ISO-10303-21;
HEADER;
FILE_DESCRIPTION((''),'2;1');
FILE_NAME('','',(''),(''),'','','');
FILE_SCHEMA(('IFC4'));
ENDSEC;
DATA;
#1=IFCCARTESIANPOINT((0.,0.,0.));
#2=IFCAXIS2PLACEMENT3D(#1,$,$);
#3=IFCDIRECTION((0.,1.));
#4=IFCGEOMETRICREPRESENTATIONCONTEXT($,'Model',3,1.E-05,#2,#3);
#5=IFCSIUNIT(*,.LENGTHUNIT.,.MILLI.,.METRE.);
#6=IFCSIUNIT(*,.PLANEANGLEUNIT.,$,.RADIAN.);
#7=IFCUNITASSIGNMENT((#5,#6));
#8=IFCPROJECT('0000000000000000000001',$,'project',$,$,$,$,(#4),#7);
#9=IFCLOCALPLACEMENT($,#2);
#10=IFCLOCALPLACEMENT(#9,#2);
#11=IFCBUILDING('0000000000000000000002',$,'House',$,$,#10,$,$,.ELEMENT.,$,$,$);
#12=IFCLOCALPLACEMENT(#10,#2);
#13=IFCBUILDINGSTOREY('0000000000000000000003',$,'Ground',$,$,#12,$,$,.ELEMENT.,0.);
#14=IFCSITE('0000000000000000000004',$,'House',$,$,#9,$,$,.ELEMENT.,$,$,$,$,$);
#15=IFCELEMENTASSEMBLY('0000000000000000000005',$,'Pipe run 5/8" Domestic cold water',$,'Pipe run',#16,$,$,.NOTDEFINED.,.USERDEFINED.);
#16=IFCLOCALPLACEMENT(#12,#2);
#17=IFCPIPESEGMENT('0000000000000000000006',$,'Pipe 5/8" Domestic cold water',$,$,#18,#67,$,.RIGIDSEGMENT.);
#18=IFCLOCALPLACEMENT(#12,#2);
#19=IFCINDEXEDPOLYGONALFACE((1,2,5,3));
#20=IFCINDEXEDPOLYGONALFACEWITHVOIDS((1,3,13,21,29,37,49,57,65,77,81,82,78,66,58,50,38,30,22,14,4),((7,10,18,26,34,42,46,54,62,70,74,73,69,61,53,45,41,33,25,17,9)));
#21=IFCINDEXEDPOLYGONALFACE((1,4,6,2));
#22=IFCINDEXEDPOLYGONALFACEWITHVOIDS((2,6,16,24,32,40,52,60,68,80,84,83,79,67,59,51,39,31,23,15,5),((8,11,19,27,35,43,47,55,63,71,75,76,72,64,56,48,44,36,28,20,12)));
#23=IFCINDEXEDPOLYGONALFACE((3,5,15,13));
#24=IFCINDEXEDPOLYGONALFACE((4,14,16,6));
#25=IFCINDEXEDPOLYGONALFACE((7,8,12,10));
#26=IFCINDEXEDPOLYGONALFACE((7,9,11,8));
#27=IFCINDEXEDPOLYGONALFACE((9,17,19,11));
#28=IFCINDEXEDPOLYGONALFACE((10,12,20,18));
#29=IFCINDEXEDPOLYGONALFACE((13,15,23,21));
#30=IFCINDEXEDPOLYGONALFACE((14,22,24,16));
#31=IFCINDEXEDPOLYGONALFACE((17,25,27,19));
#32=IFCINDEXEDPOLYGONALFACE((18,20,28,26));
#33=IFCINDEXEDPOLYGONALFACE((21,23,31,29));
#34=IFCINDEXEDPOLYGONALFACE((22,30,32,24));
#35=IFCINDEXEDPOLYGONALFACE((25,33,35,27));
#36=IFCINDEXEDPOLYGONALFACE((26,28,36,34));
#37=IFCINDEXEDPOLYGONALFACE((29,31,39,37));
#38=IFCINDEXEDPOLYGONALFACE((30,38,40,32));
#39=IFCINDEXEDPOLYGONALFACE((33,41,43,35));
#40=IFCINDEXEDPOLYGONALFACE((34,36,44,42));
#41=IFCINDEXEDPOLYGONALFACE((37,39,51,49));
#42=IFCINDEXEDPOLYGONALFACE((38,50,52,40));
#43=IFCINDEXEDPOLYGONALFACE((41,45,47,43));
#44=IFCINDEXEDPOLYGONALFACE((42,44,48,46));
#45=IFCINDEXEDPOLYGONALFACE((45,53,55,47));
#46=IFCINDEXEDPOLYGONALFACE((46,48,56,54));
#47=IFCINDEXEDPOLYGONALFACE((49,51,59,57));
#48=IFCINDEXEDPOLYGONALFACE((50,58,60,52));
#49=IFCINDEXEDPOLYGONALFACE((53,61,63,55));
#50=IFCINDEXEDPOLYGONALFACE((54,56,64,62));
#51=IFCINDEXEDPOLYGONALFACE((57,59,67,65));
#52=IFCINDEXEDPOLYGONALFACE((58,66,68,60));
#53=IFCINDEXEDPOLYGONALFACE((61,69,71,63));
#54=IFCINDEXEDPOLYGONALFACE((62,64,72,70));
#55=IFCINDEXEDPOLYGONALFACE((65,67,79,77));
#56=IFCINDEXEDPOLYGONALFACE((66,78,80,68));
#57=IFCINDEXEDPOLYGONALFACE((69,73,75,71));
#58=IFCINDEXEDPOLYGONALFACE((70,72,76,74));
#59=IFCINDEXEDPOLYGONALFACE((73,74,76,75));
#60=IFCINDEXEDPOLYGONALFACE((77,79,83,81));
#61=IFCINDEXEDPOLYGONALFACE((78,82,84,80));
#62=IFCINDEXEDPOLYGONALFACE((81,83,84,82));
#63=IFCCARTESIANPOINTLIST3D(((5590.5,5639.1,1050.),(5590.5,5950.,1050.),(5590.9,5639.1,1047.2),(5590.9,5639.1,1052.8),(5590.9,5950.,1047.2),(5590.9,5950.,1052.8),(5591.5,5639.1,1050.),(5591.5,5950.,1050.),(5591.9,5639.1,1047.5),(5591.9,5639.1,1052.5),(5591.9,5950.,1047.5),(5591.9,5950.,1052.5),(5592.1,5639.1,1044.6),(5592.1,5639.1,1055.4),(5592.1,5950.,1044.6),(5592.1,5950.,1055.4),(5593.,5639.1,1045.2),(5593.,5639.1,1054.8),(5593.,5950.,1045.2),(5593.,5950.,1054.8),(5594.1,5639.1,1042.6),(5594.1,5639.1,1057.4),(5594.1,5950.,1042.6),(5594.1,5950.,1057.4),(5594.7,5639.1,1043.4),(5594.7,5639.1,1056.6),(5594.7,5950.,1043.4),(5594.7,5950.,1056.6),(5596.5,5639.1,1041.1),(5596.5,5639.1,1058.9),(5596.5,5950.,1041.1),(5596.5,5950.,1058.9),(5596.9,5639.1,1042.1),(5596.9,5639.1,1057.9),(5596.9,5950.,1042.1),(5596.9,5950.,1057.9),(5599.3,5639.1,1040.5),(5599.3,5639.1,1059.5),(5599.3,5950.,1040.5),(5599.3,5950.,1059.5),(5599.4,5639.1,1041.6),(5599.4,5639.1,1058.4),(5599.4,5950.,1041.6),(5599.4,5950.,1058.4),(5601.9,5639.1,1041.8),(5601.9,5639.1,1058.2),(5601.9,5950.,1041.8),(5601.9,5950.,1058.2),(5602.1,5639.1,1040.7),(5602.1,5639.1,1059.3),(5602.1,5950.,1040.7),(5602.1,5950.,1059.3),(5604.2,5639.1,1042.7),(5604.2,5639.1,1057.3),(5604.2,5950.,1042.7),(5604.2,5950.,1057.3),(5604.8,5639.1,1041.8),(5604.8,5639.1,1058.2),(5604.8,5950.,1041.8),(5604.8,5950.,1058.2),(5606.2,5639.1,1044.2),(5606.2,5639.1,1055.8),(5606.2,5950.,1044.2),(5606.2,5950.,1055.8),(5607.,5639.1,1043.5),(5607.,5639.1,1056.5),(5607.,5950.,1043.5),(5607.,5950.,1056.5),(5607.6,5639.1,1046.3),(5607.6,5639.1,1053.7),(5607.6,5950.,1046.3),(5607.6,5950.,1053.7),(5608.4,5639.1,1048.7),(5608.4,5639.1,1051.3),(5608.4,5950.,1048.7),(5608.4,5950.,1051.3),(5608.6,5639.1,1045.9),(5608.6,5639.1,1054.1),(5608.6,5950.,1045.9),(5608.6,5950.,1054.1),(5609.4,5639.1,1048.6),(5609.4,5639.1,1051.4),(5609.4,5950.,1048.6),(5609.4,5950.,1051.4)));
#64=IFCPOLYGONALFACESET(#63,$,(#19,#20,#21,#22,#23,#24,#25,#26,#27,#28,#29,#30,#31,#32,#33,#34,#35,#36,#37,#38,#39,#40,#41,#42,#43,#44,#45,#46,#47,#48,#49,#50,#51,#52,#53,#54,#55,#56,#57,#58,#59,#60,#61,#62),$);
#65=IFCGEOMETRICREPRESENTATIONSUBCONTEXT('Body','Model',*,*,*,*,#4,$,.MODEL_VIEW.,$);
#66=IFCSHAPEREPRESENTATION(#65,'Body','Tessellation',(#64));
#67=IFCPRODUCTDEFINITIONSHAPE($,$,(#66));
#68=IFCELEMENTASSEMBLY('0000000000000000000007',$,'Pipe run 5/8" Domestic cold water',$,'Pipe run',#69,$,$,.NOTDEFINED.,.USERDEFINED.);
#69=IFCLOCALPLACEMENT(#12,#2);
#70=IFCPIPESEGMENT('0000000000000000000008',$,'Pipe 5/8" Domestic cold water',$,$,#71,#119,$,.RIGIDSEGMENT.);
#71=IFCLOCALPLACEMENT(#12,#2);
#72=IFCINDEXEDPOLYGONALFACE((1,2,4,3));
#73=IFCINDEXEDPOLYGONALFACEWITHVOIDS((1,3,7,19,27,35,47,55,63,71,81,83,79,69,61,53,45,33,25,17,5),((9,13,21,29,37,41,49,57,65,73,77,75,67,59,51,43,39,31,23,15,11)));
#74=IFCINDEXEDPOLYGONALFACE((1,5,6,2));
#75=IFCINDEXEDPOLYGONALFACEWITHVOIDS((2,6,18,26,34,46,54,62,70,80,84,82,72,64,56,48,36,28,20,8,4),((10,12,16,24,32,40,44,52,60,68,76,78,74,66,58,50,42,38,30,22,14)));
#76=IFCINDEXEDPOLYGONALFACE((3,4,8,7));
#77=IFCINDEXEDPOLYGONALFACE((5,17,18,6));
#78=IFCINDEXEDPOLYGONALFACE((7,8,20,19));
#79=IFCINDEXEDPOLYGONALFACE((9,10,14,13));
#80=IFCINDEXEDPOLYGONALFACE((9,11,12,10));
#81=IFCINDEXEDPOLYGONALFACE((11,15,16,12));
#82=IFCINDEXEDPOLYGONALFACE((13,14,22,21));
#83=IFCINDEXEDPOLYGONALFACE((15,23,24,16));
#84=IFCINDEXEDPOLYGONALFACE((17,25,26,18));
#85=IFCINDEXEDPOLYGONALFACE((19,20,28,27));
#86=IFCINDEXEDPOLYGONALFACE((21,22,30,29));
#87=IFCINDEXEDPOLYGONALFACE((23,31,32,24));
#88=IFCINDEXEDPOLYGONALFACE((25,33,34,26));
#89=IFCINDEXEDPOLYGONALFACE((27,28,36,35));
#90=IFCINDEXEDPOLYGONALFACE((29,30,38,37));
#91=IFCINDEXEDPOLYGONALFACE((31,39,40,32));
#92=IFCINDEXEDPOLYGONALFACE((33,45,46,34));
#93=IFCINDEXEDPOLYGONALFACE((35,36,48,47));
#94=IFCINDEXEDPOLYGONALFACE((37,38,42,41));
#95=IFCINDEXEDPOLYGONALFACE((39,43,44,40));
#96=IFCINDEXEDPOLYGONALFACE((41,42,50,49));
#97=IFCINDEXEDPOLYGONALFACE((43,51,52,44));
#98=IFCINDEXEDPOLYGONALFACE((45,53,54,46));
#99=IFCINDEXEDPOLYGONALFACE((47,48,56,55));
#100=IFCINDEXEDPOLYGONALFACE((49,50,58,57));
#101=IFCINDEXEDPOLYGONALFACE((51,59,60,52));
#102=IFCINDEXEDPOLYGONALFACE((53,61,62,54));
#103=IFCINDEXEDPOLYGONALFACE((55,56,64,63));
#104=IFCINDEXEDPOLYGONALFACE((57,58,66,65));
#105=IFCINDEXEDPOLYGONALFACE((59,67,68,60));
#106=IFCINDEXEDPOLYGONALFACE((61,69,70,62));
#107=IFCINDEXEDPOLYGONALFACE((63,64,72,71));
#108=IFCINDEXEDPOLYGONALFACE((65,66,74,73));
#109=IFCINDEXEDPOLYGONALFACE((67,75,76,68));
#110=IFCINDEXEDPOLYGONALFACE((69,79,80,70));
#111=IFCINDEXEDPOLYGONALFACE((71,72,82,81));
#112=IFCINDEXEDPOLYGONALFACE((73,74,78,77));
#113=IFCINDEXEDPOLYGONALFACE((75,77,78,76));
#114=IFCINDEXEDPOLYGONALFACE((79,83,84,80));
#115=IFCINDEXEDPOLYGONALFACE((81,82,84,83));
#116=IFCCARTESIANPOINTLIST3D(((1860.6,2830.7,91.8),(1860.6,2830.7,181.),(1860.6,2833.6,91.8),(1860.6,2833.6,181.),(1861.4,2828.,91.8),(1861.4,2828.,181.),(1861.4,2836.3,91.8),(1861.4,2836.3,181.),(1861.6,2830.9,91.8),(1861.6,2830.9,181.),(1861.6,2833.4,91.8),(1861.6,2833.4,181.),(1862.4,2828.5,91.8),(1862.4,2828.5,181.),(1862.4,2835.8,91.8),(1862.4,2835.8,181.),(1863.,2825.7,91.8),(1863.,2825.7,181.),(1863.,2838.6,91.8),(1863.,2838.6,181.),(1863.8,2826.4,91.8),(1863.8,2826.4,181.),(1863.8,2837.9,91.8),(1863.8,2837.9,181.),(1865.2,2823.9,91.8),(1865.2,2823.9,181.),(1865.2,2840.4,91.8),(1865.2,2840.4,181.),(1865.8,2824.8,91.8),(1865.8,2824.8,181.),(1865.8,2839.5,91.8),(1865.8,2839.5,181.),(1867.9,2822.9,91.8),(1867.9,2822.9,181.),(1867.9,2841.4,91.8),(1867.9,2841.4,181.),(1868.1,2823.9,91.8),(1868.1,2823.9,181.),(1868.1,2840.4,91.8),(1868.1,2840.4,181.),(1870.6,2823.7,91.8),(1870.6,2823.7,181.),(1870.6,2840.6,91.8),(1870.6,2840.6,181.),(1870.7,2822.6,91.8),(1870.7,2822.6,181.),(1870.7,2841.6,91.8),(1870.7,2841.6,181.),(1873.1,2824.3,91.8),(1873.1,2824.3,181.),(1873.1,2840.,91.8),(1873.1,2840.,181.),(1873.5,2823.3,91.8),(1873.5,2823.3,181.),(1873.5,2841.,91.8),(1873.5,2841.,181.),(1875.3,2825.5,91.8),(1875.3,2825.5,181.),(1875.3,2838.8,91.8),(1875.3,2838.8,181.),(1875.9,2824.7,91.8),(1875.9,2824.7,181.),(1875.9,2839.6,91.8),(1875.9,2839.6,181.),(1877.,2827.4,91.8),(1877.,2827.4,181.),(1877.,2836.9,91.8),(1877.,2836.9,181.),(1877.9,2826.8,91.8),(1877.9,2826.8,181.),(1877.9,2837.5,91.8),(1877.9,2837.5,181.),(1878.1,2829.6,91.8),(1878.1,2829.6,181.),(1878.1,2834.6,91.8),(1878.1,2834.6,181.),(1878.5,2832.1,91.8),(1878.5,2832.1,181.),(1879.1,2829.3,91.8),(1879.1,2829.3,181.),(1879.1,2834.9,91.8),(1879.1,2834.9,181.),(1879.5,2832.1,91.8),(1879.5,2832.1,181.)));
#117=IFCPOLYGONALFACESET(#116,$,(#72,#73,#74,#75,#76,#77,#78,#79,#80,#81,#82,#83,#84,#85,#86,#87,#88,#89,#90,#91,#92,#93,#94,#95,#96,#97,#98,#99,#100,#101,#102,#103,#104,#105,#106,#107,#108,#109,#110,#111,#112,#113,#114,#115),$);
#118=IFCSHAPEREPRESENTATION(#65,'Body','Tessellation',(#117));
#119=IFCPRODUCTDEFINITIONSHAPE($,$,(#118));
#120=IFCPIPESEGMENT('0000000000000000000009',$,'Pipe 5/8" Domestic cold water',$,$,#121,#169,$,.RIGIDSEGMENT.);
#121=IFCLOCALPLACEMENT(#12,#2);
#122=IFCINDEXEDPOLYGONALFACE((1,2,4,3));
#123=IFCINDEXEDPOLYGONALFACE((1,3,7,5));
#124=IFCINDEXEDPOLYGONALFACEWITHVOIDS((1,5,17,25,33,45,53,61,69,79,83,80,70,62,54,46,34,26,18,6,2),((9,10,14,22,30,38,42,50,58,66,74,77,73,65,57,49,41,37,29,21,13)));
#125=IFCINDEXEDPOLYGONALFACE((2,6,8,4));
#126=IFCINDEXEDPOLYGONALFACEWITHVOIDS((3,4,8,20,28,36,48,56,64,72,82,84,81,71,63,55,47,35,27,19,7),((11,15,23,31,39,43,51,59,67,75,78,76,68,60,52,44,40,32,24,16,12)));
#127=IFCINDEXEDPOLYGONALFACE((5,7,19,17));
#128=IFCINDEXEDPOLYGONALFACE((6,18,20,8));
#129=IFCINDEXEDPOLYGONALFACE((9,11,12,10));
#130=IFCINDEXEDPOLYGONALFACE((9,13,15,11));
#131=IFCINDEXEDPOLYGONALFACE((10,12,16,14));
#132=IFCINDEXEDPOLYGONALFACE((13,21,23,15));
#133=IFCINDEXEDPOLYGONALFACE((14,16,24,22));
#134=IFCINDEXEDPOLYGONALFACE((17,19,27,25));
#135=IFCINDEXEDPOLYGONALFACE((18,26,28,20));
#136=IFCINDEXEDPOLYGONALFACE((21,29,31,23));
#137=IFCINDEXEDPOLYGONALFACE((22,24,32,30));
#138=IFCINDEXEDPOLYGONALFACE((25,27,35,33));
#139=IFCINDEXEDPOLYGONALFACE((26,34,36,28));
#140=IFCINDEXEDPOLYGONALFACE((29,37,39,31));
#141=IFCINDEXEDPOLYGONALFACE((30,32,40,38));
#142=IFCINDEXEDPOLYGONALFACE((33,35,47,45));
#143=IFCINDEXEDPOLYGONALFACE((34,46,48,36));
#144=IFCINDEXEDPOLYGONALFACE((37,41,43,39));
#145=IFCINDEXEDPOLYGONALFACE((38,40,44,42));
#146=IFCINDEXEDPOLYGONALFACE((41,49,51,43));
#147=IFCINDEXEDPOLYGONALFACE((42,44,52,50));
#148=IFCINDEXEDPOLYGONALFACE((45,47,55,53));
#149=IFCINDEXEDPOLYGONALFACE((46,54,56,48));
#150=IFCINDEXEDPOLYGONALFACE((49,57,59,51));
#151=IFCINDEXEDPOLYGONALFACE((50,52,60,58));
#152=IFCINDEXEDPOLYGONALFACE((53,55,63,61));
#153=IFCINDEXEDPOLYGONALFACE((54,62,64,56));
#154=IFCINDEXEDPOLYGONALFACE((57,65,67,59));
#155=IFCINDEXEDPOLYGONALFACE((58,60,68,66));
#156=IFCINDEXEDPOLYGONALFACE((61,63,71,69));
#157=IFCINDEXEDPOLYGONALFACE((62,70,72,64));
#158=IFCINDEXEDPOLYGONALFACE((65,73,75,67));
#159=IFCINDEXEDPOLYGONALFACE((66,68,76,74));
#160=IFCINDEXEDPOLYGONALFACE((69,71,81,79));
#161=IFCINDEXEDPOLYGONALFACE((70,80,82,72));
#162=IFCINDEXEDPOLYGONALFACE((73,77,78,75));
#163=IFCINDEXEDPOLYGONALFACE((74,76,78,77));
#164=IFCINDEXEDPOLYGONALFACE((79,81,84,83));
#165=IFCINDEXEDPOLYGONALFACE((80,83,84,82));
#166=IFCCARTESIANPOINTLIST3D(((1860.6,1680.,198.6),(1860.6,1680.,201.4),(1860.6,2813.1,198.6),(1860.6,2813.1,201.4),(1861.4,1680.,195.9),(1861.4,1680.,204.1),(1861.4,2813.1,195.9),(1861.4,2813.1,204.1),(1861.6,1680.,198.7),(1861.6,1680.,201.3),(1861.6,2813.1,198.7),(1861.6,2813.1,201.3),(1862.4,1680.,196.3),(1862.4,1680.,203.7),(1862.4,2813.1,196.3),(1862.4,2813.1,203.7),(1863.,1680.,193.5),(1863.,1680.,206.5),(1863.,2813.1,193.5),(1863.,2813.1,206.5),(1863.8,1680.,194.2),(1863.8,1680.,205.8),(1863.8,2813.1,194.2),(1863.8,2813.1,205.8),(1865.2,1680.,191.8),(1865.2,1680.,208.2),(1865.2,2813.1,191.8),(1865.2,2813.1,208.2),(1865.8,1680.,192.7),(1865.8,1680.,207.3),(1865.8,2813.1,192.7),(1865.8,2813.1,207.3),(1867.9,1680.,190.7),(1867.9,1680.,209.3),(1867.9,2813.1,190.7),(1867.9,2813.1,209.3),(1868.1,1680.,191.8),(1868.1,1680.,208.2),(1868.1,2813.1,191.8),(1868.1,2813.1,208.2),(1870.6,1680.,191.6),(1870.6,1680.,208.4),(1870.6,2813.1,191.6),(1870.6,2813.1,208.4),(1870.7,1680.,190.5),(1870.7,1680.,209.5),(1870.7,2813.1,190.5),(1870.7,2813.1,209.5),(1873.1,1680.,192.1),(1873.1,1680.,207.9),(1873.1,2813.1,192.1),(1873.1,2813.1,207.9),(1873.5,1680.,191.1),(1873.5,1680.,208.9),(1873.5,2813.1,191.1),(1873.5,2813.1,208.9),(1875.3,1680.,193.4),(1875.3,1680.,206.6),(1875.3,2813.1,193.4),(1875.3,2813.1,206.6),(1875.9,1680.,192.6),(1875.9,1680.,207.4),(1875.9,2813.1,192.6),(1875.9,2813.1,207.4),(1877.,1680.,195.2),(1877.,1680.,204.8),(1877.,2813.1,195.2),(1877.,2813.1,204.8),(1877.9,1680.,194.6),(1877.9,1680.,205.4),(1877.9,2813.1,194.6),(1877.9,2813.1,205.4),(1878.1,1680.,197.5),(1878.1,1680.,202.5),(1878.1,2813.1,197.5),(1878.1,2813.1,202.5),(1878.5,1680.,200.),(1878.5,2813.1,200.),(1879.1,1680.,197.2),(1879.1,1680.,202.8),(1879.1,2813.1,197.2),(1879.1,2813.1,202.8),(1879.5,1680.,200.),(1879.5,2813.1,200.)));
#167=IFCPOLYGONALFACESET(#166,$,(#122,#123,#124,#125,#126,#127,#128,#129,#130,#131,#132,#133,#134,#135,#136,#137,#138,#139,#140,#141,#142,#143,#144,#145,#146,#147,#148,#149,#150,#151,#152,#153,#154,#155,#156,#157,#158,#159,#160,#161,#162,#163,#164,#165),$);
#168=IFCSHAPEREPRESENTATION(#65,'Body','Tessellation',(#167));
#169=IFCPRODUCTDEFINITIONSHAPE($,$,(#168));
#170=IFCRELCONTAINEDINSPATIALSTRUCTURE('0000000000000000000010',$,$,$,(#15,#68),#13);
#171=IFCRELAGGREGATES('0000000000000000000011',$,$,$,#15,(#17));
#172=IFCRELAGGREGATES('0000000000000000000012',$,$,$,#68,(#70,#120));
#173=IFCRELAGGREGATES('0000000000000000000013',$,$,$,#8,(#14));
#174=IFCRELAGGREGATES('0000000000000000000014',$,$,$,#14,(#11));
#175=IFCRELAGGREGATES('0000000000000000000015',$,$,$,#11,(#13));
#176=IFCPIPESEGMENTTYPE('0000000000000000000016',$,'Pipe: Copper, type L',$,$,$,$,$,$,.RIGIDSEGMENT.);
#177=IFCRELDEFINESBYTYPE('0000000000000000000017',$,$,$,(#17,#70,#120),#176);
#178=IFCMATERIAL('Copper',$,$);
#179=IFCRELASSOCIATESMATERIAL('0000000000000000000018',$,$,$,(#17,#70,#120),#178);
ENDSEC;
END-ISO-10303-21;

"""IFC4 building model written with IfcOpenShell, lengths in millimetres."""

from ifc_helpers import new_model, si_unit, direction, frame, origin, origin_with_axes, origin_2d, place, context, subcontext, project, spatial, hollow_circle, extrude, material, type_object, element, aggregate, save


model = new_model("IFC4")

# Units and contexts
model_context = context("Model", 3, precision=1e-05, world=origin(), true_north=direction((0.0, 1.0)))
body_context = subcontext(model_context, "Body", "Model", "MODEL_VIEW")
ifc_project = project(units=[si_unit("LENGTHUNIT", "METRE", prefix="MILLI"), si_unit("PLANEANGLEUNIT", "RADIAN")], contexts=[model_context])

# Site, building, storey
site_placement = place(None, origin())
site = spatial("IfcSite", under=ifc_project, at=site_placement, Name="House", CompositionType="ELEMENT")
building_placement = place(site_placement, origin())
building = spatial("IfcBuilding", under=site, at=building_placement, Name="House", CompositionType="ELEMENT")
storey_placement = place(building_placement, origin())
storey = spatial("IfcBuildingStorey", under=building, at=storey_placement, Name="Ground", CompositionType="ELEMENT", Elevation=0.0)

# Element assembly, pipe segment
assembly_1_placement = place(storey_placement, origin_with_axes())
assembly_1 = element("IfcElementAssembly", 1, at=assembly_1_placement, inside=storey, Name="Pipe run 5/8\" Domestic cold water", ObjectType="Pipe run", AssemblyPlace="NOTDEFINED", PredefinedType="USERDEFINED")
ifc_material = material(Name="Copper")
pipe_segment_type = type_object("IfcPipeSegmentType", Name="Pipe: Copper, type L", PredefinedType="RIGIDSEGMENT")
pipe_segment_1_placement = place(storey_placement, origin_with_axes())
pipe_segment_1 = element("IfcPipeSegment", 2, at=pipe_segment_1_placement, type_object=pipe_segment_type, material=ifc_material, Name="Pipe 5/8\" Domestic cold water", PredefinedType="RIGIDSEGMENT", context=body_context, shape_type="SweptSolid", body=[
    extrude(hollow_circle(Radius=9.5, WallThickness=1.1, at=origin_2d()), frame((5600.0, 5639.1, 1050.0), z_axis=(0.0, 1.0, 0.0), x_axis=(-1.0, 0.0, 0.0)), (0.0, 0.0, 1.0), 310.9),
])
aggregate(assembly_1, [pipe_segment_1])

# Element assembly, pipe segments
assembly_2_placement = place(storey_placement, origin_with_axes())
assembly_2 = element("IfcElementAssembly", 3, at=assembly_2_placement, inside=storey, Name="Pipe run 5/8\" Domestic cold water", ObjectType="Pipe run", AssemblyPlace="NOTDEFINED", PredefinedType="USERDEFINED")
pipe_segment_2_placement = place(storey_placement, origin_with_axes())
pipe_segment_2 = element("IfcPipeSegment", 4, at=pipe_segment_2_placement, type_object=pipe_segment_type, material=ifc_material, Name="Pipe 5/8\" Domestic cold water", PredefinedType="RIGIDSEGMENT", context=body_context, shape_type="SweptSolid", body=[
    extrude(hollow_circle(Radius=9.5, WallThickness=1.1, at=origin_2d()), frame((1870.0, 2832.1, 91.8), z_axis=(0.0, 0.0, 1.0), x_axis=(1.0, 0.0, 0.0)), (0.0, 0.0, 1.0), 89.1),
])
pipe_segment_3_placement = place(storey_placement, origin_with_axes())
pipe_segment_3 = element("IfcPipeSegment", 5, at=pipe_segment_3_placement, type_object=pipe_segment_type, material=ifc_material, Name="Pipe 5/8\" Domestic cold water", PredefinedType="RIGIDSEGMENT", context=body_context, shape_type="SweptSolid", body=[
    extrude(hollow_circle(Radius=9.5, WallThickness=1.1, at=origin_2d()), frame((1870.0, 2813.1, 200.0), z_axis=(0.0, -1.0, 0.0), x_axis=(1.0, 0.0, 0.0)), (0.0, 0.0, 1.0), 1133.1),
])

aggregate(assembly_2, [pipe_segment_2, pipe_segment_3])

save(model, "model.ifc")
